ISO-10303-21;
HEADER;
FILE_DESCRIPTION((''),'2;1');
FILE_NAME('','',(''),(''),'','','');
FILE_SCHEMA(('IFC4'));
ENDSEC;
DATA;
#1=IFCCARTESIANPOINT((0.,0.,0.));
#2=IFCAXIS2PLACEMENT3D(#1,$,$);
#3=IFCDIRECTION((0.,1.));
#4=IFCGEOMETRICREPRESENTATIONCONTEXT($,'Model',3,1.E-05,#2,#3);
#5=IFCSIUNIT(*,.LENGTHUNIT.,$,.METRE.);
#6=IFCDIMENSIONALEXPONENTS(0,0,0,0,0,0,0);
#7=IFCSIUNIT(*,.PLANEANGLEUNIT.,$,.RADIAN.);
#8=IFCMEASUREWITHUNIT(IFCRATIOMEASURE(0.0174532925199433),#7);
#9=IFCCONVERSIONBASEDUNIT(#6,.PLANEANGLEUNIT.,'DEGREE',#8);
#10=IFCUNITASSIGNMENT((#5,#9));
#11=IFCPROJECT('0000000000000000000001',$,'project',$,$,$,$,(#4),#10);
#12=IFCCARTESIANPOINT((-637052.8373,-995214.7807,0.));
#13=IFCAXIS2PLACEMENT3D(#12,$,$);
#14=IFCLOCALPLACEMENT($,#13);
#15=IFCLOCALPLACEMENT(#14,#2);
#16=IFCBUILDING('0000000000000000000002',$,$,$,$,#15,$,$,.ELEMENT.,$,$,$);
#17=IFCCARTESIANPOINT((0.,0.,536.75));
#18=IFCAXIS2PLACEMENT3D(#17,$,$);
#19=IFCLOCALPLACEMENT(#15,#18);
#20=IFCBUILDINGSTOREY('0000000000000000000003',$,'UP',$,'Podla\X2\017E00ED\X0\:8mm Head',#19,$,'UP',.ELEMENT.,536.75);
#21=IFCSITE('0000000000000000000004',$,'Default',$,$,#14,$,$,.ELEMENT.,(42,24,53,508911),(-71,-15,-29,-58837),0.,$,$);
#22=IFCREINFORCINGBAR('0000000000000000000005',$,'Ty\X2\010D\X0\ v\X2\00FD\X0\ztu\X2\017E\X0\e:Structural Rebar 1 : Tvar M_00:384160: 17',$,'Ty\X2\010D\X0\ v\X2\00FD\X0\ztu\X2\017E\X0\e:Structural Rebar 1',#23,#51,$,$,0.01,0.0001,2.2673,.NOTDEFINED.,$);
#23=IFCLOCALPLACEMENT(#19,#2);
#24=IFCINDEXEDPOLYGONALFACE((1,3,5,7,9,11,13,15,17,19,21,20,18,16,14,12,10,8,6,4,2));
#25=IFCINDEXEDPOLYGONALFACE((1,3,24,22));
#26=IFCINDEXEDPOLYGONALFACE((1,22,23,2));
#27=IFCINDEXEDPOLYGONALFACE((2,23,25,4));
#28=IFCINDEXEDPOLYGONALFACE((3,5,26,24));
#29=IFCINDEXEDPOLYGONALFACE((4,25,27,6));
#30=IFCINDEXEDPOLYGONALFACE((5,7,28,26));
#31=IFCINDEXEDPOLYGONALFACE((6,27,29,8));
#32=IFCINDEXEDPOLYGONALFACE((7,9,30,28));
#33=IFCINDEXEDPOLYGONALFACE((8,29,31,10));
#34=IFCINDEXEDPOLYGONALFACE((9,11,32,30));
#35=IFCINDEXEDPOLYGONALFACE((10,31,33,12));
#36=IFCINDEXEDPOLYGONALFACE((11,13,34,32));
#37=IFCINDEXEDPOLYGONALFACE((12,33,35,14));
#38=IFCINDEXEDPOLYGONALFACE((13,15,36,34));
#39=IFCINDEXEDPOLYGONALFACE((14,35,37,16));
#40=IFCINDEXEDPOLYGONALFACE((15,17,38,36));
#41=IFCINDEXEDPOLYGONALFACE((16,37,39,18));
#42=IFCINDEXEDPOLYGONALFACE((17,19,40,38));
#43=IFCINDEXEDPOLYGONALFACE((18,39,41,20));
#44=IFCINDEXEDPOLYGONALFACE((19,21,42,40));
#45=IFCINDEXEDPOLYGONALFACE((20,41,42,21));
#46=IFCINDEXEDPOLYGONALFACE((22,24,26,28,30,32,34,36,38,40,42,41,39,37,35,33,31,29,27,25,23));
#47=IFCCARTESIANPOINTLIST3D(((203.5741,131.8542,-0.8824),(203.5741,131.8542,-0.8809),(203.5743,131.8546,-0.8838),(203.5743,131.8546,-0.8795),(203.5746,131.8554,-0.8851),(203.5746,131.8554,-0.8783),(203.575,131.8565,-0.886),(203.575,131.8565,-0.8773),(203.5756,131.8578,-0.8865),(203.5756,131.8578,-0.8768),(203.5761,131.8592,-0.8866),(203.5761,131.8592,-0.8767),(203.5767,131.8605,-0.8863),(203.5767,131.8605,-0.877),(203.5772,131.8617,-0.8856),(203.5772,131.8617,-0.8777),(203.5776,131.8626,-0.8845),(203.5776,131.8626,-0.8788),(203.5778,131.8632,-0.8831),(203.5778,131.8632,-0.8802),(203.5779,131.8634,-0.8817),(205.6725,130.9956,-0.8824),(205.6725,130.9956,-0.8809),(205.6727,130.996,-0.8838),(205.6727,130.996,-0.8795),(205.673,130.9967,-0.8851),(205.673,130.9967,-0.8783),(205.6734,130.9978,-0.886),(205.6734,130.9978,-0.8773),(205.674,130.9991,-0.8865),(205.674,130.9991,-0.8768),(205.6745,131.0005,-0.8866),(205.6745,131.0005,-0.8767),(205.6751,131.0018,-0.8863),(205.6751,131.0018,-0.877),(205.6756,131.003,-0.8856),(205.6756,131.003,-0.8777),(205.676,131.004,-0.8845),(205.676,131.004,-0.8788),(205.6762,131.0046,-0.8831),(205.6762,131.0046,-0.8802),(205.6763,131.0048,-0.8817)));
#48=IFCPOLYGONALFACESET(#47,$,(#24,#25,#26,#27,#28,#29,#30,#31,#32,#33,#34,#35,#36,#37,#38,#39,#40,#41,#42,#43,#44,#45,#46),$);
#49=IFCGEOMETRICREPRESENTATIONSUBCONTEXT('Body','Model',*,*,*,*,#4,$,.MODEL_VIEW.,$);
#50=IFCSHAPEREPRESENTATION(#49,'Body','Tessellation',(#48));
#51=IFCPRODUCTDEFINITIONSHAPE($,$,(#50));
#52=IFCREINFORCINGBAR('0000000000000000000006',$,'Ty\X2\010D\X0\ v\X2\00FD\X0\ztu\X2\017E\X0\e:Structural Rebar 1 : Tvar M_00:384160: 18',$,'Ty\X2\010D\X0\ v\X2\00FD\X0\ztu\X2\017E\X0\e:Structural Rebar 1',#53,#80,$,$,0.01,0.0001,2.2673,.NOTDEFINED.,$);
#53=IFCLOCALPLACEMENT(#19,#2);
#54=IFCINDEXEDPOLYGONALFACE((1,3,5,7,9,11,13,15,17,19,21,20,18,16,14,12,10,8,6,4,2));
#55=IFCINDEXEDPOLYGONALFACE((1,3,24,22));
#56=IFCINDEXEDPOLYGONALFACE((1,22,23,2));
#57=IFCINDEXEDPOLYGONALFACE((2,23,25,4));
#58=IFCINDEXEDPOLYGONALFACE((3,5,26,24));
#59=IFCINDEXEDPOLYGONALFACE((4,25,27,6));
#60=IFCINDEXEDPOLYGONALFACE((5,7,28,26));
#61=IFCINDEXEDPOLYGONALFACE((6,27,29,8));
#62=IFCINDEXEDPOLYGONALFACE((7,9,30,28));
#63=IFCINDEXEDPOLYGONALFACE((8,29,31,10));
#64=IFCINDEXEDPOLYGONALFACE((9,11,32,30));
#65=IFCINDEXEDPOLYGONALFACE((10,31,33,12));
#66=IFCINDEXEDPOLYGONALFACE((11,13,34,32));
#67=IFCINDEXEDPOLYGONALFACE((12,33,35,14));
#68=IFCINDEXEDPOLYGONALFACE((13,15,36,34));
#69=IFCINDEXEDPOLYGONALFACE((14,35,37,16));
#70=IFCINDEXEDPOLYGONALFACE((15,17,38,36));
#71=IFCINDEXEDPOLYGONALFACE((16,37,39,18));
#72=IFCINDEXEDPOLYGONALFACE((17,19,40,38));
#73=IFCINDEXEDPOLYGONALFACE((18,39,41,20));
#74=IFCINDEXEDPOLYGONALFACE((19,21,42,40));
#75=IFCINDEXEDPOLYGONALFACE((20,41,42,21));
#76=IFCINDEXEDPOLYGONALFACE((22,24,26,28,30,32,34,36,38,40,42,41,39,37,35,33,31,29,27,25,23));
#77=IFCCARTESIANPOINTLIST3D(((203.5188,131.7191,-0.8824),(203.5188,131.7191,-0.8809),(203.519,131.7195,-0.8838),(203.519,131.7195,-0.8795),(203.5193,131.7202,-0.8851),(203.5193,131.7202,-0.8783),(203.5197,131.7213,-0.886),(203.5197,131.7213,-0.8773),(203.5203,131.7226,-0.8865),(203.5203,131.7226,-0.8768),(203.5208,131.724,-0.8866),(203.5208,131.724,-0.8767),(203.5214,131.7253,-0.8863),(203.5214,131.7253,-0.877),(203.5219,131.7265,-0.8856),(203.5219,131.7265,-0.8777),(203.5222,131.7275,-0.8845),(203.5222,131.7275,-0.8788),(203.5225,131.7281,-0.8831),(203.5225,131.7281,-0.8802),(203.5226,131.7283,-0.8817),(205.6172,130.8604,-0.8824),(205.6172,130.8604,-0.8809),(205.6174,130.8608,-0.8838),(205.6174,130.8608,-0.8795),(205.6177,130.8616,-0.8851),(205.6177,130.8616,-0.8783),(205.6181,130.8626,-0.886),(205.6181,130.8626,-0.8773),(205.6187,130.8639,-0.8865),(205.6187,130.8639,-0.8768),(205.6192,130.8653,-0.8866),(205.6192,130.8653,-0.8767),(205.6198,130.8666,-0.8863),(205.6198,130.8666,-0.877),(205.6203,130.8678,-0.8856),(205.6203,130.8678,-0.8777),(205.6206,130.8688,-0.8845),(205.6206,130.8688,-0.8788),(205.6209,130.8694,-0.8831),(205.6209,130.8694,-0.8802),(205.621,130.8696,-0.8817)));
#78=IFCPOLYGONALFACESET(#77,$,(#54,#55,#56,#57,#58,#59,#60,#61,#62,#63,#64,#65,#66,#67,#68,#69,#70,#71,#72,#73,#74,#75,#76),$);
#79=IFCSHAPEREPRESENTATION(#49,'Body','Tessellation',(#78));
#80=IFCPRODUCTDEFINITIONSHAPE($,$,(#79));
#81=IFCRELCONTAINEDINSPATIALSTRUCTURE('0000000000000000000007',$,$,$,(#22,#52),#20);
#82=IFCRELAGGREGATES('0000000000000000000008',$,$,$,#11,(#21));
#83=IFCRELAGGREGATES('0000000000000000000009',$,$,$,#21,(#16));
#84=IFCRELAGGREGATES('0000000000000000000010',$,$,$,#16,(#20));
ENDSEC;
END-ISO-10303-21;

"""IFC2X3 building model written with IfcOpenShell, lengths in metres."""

from ifc_helpers import new_model, entity, si_unit, converted_unit, direction, frame, origin, place, context, subcontext, project, spatial, element, save


model = new_model("IFC2X3")

# Units and contexts
model_context = context("Model", 3, precision=1e-05, world=origin(), true_north=direction((0.0, 1.0)))
body_context = subcontext(model_context, "Body", "Model", "MODEL_VIEW")
ifc_project = project(units=[si_unit("LENGTHUNIT", "METRE"), converted_unit("PLANEANGLEUNIT", "DEGREE", entity("IfcRatioMeasure", 0.0174532925199433), si_unit("PLANEANGLEUNIT", "RADIAN"), dimensions=[0, 0, 0, 0, 0, 0, 0])], contexts=[model_context])

# Site, building, storey
site_placement = place(None, frame((-637052.8373, -995214.7807, 0.0)))
site = spatial("IfcSite", under=ifc_project, at=site_placement, Name="Default", CompositionType="ELEMENT", RefLatitude=(42, 24, 53, 508911), RefLongitude=(-71, -15, -29, -58837), RefElevation=0.0)
building_placement = place(site_placement, origin())
building = spatial("IfcBuilding", under=site, at=building_placement, CompositionType="ELEMENT")
storey_placement = place(building_placement, frame((0.0, 0.0, 536.75)))
storey = spatial("IfcBuildingStorey", under=building, at=storey_placement, Name="UP", ObjectType="Podlaží:8mm Head", LongName="UP", CompositionType="ELEMENT", Elevation=536.75)

# Reinforcing bars
reinforcing_bar_1_placement = place(storey_placement, origin())
element("IfcReinforcingBar", 1, at=reinforcing_bar_1_placement, inside=storey, Name="Tyč výztuže:Structural Rebar 1 : Tvar M_00:384160: 17", ObjectType="Tyč výztuže:Structural Rebar 1", BarLength=2.2673, BarRole="NOTDEFINED", CrossSectionArea=0.0001, NominalDiameter=0.01, context=body_context, shape_type="AdvancedSweptSolid", body=[
    entity("IfcSweptDiskSolid", entity("IfcCompositeCurve", [entity("IfcCompositeCurveSegment", "CONTINUOUS", True, entity("IfcPolyline", [entity("IfcCartesianPoint", [-205.6744, -131.0001, 0.8817]), entity("IfcCartesianPoint", [-203.576, -131.8588, 0.8817])]))], False), 0.005, None, 0.0, 1.0),
])
reinforcing_bar_2_placement = place(storey_placement, origin())
element("IfcReinforcingBar", 2, at=reinforcing_bar_2_placement, inside=storey, Name="Tyč výztuže:Structural Rebar 1 : Tvar M_00:384160: 18", ObjectType="Tyč výztuže:Structural Rebar 1", BarLength=2.2673, BarRole="NOTDEFINED", CrossSectionArea=0.0001, NominalDiameter=0.01, context=body_context, shape_type="AdvancedSweptSolid", body=[
    entity("IfcSweptDiskSolid", entity("IfcCompositeCurve", [entity("IfcCompositeCurveSegment", "CONTINUOUS", True, entity("IfcPolyline", [entity("IfcCartesianPoint", [-205.6191, -130.865, 0.8817]), entity("IfcCartesianPoint", [-203.5207, -131.7236, 0.8817])]))], False), 0.005, None, 0.0, 1.0),
])

save(model, "model.ifc")
